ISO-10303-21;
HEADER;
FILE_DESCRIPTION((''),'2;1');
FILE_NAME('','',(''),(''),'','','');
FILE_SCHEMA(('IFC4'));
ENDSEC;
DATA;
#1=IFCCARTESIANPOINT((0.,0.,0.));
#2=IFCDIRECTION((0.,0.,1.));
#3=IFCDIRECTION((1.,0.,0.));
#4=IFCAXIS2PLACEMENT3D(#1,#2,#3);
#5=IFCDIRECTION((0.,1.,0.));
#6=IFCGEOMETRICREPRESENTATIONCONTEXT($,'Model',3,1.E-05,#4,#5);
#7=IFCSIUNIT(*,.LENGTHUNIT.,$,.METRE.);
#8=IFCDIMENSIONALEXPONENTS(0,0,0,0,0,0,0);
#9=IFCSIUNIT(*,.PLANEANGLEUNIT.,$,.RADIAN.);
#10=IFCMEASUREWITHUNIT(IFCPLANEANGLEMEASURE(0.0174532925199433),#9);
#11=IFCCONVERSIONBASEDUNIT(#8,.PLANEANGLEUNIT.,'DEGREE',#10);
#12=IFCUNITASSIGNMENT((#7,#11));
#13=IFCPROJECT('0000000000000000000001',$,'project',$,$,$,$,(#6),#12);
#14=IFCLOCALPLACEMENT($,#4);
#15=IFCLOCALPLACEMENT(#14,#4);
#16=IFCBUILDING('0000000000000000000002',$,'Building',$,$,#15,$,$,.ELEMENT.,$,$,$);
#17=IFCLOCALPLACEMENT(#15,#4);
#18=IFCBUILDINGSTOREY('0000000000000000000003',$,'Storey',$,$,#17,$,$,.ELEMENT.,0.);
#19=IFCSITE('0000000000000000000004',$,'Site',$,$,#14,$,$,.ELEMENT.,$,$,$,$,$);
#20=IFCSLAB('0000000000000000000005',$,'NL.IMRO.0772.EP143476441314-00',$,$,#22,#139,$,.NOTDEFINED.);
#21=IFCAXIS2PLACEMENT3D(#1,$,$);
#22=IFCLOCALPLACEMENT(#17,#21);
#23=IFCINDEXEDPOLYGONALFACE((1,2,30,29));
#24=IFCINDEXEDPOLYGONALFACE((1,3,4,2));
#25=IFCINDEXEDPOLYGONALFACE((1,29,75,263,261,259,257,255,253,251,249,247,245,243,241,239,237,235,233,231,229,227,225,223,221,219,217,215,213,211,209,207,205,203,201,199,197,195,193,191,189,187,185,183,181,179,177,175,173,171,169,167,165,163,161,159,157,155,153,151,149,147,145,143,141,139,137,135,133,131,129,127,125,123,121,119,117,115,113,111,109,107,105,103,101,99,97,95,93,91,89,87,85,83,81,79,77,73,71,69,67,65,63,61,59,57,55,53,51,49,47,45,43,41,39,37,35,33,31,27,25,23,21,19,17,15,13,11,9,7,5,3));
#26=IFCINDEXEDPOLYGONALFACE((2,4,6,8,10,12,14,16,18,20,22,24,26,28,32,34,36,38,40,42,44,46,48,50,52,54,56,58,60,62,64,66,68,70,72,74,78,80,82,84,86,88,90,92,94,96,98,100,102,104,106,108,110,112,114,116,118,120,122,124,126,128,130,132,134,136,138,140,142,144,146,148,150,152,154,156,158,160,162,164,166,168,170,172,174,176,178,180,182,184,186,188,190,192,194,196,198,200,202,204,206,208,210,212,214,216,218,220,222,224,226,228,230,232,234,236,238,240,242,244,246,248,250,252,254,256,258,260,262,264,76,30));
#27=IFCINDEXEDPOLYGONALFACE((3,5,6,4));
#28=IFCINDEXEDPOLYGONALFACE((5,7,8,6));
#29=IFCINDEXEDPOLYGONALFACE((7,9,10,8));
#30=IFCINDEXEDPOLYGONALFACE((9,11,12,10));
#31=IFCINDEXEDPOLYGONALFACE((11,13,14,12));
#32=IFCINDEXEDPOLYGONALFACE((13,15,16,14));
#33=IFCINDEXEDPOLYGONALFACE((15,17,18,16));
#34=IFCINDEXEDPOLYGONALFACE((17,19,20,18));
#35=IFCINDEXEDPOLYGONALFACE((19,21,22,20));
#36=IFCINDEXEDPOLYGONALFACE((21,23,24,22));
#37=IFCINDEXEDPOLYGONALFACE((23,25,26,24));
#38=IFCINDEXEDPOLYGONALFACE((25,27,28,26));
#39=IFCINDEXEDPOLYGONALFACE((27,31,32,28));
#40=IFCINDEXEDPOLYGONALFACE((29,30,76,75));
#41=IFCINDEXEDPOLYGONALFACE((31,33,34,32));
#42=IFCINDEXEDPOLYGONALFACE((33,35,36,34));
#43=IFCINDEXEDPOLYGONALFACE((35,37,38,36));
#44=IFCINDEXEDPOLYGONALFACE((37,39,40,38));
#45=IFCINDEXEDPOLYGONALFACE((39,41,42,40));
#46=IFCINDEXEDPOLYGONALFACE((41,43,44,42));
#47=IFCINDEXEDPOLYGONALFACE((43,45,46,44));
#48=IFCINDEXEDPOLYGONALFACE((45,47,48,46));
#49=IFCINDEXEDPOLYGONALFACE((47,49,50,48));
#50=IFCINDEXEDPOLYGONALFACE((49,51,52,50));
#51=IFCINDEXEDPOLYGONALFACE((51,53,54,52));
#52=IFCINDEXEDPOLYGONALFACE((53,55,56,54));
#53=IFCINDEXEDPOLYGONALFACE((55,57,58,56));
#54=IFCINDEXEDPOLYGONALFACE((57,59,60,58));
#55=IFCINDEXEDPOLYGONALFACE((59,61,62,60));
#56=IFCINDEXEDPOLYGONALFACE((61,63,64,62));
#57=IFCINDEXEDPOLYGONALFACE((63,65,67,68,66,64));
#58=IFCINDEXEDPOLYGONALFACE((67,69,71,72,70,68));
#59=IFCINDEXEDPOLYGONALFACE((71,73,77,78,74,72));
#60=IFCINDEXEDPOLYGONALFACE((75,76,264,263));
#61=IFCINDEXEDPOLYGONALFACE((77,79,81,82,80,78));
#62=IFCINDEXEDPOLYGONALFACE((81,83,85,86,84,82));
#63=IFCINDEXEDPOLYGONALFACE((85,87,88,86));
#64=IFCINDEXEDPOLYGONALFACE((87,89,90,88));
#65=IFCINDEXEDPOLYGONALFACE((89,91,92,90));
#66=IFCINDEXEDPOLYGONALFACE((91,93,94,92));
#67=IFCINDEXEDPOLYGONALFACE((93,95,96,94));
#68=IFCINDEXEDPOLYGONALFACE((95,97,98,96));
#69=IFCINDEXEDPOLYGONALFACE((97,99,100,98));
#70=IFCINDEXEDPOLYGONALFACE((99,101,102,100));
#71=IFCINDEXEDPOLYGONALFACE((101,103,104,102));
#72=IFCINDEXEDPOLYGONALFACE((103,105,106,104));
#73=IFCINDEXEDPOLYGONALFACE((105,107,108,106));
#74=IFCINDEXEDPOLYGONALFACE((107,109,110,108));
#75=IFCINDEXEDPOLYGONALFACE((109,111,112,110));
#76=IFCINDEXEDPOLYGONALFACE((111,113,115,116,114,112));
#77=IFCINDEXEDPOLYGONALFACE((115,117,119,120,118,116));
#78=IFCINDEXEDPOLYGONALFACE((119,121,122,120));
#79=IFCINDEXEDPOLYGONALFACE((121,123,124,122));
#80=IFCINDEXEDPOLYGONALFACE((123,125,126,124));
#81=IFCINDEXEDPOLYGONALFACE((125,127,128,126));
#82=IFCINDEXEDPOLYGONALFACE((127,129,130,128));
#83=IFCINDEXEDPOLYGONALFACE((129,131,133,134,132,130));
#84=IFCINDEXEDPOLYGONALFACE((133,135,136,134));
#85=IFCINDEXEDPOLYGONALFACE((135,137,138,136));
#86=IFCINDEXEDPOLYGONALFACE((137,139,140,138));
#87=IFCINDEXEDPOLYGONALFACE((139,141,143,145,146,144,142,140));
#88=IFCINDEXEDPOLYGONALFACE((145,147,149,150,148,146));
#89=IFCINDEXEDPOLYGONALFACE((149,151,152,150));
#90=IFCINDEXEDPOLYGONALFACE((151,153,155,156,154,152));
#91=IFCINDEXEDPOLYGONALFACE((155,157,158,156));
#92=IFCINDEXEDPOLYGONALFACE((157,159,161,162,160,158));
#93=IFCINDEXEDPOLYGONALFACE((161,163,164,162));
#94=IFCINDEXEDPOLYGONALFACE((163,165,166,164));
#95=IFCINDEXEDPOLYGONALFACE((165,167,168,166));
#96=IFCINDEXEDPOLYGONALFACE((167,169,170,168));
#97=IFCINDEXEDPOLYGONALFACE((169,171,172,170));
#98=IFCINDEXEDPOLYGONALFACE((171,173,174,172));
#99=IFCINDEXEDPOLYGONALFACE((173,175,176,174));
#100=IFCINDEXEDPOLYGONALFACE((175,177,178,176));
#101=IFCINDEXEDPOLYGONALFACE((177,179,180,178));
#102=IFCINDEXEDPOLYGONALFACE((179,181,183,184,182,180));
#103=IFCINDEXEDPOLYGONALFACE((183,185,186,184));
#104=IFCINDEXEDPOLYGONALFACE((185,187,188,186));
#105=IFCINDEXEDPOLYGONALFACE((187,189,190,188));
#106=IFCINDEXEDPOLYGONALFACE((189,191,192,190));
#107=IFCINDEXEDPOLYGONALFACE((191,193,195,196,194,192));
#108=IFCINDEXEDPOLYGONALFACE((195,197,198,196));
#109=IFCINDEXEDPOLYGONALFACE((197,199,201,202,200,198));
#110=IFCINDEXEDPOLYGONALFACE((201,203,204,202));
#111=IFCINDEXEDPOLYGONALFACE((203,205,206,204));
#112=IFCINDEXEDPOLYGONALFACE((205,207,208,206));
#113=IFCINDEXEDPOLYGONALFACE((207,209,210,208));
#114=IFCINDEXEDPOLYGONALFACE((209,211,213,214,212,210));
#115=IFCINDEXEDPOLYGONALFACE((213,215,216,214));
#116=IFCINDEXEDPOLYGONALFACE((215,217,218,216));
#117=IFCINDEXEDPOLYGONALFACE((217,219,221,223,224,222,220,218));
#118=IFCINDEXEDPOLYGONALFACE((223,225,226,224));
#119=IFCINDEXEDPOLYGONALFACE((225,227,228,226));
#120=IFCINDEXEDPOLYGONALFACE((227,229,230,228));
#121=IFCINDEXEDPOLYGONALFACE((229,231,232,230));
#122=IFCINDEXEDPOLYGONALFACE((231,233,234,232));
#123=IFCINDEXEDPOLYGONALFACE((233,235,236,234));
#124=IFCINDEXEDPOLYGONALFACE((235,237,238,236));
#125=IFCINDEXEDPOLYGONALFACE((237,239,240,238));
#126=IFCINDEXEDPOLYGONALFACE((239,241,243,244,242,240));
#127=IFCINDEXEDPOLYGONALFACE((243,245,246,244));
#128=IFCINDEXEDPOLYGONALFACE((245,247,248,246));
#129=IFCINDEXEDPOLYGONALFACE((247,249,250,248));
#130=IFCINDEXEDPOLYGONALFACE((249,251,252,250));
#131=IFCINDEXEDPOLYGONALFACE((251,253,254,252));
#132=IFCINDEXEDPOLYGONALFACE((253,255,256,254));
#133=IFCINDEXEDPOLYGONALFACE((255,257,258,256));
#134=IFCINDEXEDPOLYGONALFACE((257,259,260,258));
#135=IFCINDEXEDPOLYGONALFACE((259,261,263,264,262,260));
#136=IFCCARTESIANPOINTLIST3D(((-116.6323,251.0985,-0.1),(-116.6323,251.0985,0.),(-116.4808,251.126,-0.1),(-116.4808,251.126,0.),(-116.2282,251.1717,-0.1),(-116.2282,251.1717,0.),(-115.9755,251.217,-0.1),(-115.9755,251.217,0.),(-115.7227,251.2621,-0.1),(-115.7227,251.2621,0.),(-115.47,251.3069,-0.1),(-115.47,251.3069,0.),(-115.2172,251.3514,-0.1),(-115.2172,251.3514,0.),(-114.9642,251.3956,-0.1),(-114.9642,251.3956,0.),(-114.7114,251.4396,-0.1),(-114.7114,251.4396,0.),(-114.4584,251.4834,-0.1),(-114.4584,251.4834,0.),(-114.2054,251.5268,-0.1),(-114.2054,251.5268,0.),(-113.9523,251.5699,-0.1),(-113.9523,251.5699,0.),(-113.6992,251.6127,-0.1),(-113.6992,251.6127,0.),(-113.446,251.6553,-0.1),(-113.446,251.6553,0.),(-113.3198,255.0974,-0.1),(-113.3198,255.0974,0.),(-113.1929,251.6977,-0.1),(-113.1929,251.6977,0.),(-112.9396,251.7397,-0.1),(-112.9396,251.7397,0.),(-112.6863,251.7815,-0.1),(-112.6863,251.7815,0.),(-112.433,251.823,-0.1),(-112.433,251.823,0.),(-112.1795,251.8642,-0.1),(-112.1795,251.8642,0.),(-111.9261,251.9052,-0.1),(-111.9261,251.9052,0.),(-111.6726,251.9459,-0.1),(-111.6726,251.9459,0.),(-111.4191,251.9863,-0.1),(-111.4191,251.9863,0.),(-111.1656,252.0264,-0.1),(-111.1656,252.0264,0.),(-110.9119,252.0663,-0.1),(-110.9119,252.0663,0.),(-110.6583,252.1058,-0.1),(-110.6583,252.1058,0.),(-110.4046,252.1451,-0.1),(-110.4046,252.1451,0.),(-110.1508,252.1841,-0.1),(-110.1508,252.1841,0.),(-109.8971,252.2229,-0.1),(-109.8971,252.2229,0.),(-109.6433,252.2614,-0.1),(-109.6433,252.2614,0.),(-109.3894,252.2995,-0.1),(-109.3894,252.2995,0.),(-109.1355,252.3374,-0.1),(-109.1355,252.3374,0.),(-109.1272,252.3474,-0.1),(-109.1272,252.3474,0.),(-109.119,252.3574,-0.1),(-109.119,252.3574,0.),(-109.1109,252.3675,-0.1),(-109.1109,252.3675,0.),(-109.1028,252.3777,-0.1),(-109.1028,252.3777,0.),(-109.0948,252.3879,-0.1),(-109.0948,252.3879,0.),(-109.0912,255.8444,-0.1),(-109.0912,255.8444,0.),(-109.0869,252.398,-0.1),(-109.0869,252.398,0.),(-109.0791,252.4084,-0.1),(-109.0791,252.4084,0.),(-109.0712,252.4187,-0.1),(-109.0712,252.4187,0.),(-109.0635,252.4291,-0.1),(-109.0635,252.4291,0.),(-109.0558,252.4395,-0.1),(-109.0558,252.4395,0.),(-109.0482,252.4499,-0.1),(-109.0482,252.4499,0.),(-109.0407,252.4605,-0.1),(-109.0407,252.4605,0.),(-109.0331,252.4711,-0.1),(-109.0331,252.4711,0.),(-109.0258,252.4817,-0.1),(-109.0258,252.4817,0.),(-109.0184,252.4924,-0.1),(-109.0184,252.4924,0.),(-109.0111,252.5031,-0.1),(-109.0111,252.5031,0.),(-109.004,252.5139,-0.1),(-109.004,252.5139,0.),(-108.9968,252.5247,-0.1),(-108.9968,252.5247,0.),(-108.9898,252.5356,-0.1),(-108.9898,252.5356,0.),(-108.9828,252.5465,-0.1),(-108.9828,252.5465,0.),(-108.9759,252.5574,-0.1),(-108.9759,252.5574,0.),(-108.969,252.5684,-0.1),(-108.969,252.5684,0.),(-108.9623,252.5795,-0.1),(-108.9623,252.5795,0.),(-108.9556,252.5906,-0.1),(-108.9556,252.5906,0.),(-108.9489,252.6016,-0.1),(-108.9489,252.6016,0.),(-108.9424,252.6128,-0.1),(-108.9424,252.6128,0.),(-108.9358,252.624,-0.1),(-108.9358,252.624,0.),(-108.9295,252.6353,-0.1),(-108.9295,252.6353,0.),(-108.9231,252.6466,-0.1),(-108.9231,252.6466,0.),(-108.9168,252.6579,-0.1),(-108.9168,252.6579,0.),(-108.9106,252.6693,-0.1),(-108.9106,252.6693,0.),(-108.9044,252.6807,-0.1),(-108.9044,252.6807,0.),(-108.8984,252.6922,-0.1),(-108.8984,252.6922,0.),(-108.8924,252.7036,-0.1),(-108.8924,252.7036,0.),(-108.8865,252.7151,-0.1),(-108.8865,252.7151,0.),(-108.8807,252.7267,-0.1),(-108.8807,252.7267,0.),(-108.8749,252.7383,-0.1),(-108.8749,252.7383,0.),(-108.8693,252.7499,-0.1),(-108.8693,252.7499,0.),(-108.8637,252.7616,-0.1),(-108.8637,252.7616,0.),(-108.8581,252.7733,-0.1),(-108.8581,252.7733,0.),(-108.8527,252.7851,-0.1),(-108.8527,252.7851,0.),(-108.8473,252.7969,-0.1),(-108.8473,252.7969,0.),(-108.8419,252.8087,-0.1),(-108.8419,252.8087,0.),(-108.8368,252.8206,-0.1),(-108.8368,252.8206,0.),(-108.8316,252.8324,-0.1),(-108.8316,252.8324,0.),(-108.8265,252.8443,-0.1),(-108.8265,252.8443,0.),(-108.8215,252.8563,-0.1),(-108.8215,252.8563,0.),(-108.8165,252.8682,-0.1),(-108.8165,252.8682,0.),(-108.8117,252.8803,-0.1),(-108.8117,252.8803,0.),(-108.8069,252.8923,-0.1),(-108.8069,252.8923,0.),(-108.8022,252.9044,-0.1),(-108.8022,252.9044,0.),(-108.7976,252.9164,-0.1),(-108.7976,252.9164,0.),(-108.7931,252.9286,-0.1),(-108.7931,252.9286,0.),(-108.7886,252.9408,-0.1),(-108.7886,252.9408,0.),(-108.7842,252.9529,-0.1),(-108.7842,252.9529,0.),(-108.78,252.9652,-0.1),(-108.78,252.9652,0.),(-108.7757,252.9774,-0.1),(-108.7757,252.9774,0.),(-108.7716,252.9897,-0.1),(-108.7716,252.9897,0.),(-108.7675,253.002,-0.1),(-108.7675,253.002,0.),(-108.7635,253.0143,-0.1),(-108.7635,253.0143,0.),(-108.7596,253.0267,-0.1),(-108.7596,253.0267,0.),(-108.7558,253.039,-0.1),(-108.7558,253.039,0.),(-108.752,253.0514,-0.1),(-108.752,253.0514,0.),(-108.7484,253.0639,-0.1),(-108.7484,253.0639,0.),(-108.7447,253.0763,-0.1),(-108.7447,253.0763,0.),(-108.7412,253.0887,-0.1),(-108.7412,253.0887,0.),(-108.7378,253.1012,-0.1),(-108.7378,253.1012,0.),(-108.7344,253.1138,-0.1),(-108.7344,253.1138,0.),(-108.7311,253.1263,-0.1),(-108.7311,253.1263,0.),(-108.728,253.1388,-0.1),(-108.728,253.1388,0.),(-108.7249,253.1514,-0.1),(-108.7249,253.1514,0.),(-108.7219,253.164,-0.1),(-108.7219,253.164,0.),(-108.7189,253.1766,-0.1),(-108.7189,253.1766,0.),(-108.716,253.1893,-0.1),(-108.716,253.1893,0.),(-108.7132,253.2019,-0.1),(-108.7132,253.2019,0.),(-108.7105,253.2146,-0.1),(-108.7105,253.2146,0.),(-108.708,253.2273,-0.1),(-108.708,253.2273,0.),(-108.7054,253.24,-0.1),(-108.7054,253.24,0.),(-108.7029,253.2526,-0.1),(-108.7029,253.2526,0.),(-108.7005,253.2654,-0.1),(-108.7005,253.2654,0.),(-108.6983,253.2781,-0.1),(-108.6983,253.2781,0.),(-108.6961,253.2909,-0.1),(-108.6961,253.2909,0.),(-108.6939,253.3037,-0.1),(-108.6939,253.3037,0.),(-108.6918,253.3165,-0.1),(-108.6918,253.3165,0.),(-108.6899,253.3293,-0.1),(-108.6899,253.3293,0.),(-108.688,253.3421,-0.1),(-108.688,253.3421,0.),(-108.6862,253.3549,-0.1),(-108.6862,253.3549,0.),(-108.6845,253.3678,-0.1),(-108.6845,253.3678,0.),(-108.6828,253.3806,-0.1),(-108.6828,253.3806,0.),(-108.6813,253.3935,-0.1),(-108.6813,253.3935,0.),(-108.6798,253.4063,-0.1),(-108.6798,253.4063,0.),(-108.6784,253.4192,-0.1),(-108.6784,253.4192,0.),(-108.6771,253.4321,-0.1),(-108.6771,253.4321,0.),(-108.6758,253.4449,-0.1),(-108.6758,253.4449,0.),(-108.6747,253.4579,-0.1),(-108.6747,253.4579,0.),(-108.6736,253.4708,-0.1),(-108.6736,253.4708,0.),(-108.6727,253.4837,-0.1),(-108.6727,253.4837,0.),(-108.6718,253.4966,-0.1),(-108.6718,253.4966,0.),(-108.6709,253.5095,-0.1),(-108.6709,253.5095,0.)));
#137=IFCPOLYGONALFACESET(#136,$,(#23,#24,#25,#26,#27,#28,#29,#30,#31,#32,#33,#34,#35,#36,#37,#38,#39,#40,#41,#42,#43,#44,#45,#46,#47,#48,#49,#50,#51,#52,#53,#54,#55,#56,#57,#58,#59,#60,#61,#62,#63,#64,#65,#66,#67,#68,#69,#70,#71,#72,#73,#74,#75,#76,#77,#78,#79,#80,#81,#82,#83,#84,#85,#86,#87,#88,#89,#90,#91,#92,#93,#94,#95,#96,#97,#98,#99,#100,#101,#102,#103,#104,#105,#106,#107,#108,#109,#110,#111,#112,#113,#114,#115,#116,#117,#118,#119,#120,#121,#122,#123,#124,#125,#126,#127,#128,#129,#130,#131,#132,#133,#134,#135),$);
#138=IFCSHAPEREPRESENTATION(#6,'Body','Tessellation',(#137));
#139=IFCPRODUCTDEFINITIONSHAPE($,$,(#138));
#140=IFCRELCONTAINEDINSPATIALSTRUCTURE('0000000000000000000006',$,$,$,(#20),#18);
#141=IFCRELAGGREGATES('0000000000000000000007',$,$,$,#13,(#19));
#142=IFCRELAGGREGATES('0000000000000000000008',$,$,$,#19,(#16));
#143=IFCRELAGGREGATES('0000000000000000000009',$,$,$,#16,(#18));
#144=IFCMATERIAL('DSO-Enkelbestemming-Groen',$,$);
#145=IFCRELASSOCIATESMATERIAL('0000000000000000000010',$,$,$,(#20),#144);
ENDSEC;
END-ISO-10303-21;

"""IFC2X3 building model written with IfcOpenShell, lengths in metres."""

from ifc_helpers import new_model, entity, si_unit, converted_unit, direction, frame, origin_with_axes, place, context, project, spatial, polyline, outline, extrude, material, element, save


model = new_model("IFC2X3")

# Units and contexts
model_context = context("Model", 3, precision=1e-05, world=origin_with_axes(), true_north=direction((0.0, 1.0, 0.0)))
ifc_project = project(units=[si_unit("LENGTHUNIT", "METRE"), converted_unit("PLANEANGLEUNIT", "DEGREE", entity("IfcPlaneAngleMeasure", 0.0174532925199433), si_unit("PLANEANGLEUNIT", "RADIAN"), dimensions=[0, 0, 0, 0, 0, 0, 0])], contexts=[model_context])

# Site, building, storey
site_placement = place(None, origin_with_axes())
site = spatial("IfcSite", under=ifc_project, at=site_placement, Name="Site", CompositionType="ELEMENT")
building_placement = place(site_placement, origin_with_axes())
building = spatial("IfcBuilding", under=site, at=building_placement, Name="Building", CompositionType="ELEMENT")
storey_placement = place(building_placement, origin_with_axes())
storey = spatial("IfcBuildingStorey", under=building, at=storey_placement, Name="Storey", CompositionType="ELEMENT", Elevation=0.0)

# Slab
ifc_material_1 = material(Name="DSO-Enkelbestemming-Groen")
slab_1_placement = place(storey_placement, frame((0.0, 0.0, -0.1), z_axis=(0.0, 0.0, 1.0), x_axis=(1.0, 0.0, 0.0)))
element("IfcSlab", 1, at=slab_1_placement, inside=storey, material=ifc_material_1, Name="NL.IMRO.0772.EP143476441314-00", PredefinedType="NOTDEFINED", context=model_context, shape_type="SweptSolid", body=[
    extrude(outline(polyline([(-109.0912, 255.8444), (-108.6709, 253.5095), (-108.6718, 253.4966), (-108.6727, 253.4837), (-108.6736, 253.4708), (-108.6747, 253.4579), (-108.6758, 253.4449), (-108.6771, 253.4321), (-108.6784, 253.4192), (-108.6798, 253.4063), (-108.6813, 253.3935), (-108.6828, 253.3806), (-108.6845, 253.3678), (-108.6862, 253.3549), (-108.688, 253.3421), (-108.6899, 253.3293), (-108.6918, 253.3165), (-108.6939, 253.3037), (-108.6961, 253.2909), (-108.6983, 253.2781), (-108.7005, 253.2654), (-108.7029, 253.2526), (-108.7054, 253.24), (-108.708, 253.2273), (-108.7105, 253.2146), (-108.7132, 253.2019), (-108.716, 253.1893), (-108.7189, 253.1766), (-108.7219, 253.164), (-108.7249, 253.1514), (-108.728, 253.1388), (-108.7311, 253.1263), (-108.7344, 253.1138), (-108.7378, 253.1012), (-108.7412, 253.0887), (-108.7447, 253.0763), (-108.7484, 253.0639), (-108.752, 253.0514), (-108.7558, 253.039), (-108.7596, 253.0267), (-108.7635, 253.0143), (-108.7675, 253.002), (-108.7716, 252.9897), (-108.7757, 252.9774), (-108.78, 252.9652), (-108.7842, 252.9529), (-108.7886, 252.9408), (-108.7931, 252.9286), (-108.7976, 252.9164), (-108.8022, 252.9044), (-108.8069, 252.8923), (-108.8117, 252.8803), (-108.8165, 252.8682), (-108.8215, 252.8563), (-108.8265, 252.8443), (-108.8316, 252.8324), (-108.8368, 252.8206), (-108.8419, 252.8087), (-108.8473, 252.7969), (-108.8527, 252.7851), (-108.8581, 252.7733), (-108.8637, 252.7616), (-108.8693, 252.7499), (-108.8749, 252.7383), (-108.8807, 252.7267), (-108.8865, 252.7151), (-108.8924, 252.7036), (-108.8984, 252.6922), (-108.9044, 252.6807), (-108.9106, 252.6693), (-108.9168, 252.6579), (-108.9231, 252.6466), (-108.9295, 252.6353), (-108.9358, 252.624), (-108.9424, 252.6128), (-108.9489, 252.6016), (-108.9556, 252.5906), (-108.9623, 252.5795), (-108.969, 252.5684), (-108.9759, 252.5574), (-108.9828, 252.5465), (-108.9898, 252.5356), (-108.9968, 252.5247), (-109.004, 252.5139), (-109.0111, 252.5031), (-109.0184, 252.4924), (-109.0258, 252.4817), (-109.0331, 252.4711), (-109.0407, 252.4605), (-109.0482, 252.4499), (-109.0558, 252.4395), (-109.0635, 252.4291), (-109.0712, 252.4187), (-109.0791, 252.4084), (-109.0869, 252.398), (-109.0948, 252.3879), (-109.1028, 252.3777), (-109.1109, 252.3675), (-109.119, 252.3574), (-109.1272, 252.3474), (-109.1355, 252.3374), (-109.3894, 252.2995), (-109.6433, 252.2614), (-109.8971, 252.2229), (-110.1508, 252.1841), (-110.4046, 252.1451), (-110.6583, 252.1058), (-110.9119, 252.0663), (-111.1656, 252.0264), (-111.4191, 251.9863), (-111.6726, 251.9459), (-111.9261, 251.9052), (-112.1795, 251.8642), (-112.433, 251.823), (-112.6863, 251.7815), (-112.9396, 251.7397), (-113.1929, 251.6977), (-113.446, 251.6553), (-113.6992, 251.6127), (-113.9523, 251.5699), (-114.2054, 251.5268), (-114.4584, 251.4834), (-114.7114, 251.4396), (-114.9642, 251.3956), (-115.2172, 251.3514), (-115.47, 251.3069), (-115.7227, 251.2621), (-115.9755, 251.217), (-116.2282, 251.1717), (-116.4808, 251.126), (-116.6323, 251.0985), (-113.3198, 255.0974), (-109.0912, 255.8444)])), origin_with_axes(), (0.0, 0.0, 1.0), 0.1),
])

save(model, "model.ifc")
